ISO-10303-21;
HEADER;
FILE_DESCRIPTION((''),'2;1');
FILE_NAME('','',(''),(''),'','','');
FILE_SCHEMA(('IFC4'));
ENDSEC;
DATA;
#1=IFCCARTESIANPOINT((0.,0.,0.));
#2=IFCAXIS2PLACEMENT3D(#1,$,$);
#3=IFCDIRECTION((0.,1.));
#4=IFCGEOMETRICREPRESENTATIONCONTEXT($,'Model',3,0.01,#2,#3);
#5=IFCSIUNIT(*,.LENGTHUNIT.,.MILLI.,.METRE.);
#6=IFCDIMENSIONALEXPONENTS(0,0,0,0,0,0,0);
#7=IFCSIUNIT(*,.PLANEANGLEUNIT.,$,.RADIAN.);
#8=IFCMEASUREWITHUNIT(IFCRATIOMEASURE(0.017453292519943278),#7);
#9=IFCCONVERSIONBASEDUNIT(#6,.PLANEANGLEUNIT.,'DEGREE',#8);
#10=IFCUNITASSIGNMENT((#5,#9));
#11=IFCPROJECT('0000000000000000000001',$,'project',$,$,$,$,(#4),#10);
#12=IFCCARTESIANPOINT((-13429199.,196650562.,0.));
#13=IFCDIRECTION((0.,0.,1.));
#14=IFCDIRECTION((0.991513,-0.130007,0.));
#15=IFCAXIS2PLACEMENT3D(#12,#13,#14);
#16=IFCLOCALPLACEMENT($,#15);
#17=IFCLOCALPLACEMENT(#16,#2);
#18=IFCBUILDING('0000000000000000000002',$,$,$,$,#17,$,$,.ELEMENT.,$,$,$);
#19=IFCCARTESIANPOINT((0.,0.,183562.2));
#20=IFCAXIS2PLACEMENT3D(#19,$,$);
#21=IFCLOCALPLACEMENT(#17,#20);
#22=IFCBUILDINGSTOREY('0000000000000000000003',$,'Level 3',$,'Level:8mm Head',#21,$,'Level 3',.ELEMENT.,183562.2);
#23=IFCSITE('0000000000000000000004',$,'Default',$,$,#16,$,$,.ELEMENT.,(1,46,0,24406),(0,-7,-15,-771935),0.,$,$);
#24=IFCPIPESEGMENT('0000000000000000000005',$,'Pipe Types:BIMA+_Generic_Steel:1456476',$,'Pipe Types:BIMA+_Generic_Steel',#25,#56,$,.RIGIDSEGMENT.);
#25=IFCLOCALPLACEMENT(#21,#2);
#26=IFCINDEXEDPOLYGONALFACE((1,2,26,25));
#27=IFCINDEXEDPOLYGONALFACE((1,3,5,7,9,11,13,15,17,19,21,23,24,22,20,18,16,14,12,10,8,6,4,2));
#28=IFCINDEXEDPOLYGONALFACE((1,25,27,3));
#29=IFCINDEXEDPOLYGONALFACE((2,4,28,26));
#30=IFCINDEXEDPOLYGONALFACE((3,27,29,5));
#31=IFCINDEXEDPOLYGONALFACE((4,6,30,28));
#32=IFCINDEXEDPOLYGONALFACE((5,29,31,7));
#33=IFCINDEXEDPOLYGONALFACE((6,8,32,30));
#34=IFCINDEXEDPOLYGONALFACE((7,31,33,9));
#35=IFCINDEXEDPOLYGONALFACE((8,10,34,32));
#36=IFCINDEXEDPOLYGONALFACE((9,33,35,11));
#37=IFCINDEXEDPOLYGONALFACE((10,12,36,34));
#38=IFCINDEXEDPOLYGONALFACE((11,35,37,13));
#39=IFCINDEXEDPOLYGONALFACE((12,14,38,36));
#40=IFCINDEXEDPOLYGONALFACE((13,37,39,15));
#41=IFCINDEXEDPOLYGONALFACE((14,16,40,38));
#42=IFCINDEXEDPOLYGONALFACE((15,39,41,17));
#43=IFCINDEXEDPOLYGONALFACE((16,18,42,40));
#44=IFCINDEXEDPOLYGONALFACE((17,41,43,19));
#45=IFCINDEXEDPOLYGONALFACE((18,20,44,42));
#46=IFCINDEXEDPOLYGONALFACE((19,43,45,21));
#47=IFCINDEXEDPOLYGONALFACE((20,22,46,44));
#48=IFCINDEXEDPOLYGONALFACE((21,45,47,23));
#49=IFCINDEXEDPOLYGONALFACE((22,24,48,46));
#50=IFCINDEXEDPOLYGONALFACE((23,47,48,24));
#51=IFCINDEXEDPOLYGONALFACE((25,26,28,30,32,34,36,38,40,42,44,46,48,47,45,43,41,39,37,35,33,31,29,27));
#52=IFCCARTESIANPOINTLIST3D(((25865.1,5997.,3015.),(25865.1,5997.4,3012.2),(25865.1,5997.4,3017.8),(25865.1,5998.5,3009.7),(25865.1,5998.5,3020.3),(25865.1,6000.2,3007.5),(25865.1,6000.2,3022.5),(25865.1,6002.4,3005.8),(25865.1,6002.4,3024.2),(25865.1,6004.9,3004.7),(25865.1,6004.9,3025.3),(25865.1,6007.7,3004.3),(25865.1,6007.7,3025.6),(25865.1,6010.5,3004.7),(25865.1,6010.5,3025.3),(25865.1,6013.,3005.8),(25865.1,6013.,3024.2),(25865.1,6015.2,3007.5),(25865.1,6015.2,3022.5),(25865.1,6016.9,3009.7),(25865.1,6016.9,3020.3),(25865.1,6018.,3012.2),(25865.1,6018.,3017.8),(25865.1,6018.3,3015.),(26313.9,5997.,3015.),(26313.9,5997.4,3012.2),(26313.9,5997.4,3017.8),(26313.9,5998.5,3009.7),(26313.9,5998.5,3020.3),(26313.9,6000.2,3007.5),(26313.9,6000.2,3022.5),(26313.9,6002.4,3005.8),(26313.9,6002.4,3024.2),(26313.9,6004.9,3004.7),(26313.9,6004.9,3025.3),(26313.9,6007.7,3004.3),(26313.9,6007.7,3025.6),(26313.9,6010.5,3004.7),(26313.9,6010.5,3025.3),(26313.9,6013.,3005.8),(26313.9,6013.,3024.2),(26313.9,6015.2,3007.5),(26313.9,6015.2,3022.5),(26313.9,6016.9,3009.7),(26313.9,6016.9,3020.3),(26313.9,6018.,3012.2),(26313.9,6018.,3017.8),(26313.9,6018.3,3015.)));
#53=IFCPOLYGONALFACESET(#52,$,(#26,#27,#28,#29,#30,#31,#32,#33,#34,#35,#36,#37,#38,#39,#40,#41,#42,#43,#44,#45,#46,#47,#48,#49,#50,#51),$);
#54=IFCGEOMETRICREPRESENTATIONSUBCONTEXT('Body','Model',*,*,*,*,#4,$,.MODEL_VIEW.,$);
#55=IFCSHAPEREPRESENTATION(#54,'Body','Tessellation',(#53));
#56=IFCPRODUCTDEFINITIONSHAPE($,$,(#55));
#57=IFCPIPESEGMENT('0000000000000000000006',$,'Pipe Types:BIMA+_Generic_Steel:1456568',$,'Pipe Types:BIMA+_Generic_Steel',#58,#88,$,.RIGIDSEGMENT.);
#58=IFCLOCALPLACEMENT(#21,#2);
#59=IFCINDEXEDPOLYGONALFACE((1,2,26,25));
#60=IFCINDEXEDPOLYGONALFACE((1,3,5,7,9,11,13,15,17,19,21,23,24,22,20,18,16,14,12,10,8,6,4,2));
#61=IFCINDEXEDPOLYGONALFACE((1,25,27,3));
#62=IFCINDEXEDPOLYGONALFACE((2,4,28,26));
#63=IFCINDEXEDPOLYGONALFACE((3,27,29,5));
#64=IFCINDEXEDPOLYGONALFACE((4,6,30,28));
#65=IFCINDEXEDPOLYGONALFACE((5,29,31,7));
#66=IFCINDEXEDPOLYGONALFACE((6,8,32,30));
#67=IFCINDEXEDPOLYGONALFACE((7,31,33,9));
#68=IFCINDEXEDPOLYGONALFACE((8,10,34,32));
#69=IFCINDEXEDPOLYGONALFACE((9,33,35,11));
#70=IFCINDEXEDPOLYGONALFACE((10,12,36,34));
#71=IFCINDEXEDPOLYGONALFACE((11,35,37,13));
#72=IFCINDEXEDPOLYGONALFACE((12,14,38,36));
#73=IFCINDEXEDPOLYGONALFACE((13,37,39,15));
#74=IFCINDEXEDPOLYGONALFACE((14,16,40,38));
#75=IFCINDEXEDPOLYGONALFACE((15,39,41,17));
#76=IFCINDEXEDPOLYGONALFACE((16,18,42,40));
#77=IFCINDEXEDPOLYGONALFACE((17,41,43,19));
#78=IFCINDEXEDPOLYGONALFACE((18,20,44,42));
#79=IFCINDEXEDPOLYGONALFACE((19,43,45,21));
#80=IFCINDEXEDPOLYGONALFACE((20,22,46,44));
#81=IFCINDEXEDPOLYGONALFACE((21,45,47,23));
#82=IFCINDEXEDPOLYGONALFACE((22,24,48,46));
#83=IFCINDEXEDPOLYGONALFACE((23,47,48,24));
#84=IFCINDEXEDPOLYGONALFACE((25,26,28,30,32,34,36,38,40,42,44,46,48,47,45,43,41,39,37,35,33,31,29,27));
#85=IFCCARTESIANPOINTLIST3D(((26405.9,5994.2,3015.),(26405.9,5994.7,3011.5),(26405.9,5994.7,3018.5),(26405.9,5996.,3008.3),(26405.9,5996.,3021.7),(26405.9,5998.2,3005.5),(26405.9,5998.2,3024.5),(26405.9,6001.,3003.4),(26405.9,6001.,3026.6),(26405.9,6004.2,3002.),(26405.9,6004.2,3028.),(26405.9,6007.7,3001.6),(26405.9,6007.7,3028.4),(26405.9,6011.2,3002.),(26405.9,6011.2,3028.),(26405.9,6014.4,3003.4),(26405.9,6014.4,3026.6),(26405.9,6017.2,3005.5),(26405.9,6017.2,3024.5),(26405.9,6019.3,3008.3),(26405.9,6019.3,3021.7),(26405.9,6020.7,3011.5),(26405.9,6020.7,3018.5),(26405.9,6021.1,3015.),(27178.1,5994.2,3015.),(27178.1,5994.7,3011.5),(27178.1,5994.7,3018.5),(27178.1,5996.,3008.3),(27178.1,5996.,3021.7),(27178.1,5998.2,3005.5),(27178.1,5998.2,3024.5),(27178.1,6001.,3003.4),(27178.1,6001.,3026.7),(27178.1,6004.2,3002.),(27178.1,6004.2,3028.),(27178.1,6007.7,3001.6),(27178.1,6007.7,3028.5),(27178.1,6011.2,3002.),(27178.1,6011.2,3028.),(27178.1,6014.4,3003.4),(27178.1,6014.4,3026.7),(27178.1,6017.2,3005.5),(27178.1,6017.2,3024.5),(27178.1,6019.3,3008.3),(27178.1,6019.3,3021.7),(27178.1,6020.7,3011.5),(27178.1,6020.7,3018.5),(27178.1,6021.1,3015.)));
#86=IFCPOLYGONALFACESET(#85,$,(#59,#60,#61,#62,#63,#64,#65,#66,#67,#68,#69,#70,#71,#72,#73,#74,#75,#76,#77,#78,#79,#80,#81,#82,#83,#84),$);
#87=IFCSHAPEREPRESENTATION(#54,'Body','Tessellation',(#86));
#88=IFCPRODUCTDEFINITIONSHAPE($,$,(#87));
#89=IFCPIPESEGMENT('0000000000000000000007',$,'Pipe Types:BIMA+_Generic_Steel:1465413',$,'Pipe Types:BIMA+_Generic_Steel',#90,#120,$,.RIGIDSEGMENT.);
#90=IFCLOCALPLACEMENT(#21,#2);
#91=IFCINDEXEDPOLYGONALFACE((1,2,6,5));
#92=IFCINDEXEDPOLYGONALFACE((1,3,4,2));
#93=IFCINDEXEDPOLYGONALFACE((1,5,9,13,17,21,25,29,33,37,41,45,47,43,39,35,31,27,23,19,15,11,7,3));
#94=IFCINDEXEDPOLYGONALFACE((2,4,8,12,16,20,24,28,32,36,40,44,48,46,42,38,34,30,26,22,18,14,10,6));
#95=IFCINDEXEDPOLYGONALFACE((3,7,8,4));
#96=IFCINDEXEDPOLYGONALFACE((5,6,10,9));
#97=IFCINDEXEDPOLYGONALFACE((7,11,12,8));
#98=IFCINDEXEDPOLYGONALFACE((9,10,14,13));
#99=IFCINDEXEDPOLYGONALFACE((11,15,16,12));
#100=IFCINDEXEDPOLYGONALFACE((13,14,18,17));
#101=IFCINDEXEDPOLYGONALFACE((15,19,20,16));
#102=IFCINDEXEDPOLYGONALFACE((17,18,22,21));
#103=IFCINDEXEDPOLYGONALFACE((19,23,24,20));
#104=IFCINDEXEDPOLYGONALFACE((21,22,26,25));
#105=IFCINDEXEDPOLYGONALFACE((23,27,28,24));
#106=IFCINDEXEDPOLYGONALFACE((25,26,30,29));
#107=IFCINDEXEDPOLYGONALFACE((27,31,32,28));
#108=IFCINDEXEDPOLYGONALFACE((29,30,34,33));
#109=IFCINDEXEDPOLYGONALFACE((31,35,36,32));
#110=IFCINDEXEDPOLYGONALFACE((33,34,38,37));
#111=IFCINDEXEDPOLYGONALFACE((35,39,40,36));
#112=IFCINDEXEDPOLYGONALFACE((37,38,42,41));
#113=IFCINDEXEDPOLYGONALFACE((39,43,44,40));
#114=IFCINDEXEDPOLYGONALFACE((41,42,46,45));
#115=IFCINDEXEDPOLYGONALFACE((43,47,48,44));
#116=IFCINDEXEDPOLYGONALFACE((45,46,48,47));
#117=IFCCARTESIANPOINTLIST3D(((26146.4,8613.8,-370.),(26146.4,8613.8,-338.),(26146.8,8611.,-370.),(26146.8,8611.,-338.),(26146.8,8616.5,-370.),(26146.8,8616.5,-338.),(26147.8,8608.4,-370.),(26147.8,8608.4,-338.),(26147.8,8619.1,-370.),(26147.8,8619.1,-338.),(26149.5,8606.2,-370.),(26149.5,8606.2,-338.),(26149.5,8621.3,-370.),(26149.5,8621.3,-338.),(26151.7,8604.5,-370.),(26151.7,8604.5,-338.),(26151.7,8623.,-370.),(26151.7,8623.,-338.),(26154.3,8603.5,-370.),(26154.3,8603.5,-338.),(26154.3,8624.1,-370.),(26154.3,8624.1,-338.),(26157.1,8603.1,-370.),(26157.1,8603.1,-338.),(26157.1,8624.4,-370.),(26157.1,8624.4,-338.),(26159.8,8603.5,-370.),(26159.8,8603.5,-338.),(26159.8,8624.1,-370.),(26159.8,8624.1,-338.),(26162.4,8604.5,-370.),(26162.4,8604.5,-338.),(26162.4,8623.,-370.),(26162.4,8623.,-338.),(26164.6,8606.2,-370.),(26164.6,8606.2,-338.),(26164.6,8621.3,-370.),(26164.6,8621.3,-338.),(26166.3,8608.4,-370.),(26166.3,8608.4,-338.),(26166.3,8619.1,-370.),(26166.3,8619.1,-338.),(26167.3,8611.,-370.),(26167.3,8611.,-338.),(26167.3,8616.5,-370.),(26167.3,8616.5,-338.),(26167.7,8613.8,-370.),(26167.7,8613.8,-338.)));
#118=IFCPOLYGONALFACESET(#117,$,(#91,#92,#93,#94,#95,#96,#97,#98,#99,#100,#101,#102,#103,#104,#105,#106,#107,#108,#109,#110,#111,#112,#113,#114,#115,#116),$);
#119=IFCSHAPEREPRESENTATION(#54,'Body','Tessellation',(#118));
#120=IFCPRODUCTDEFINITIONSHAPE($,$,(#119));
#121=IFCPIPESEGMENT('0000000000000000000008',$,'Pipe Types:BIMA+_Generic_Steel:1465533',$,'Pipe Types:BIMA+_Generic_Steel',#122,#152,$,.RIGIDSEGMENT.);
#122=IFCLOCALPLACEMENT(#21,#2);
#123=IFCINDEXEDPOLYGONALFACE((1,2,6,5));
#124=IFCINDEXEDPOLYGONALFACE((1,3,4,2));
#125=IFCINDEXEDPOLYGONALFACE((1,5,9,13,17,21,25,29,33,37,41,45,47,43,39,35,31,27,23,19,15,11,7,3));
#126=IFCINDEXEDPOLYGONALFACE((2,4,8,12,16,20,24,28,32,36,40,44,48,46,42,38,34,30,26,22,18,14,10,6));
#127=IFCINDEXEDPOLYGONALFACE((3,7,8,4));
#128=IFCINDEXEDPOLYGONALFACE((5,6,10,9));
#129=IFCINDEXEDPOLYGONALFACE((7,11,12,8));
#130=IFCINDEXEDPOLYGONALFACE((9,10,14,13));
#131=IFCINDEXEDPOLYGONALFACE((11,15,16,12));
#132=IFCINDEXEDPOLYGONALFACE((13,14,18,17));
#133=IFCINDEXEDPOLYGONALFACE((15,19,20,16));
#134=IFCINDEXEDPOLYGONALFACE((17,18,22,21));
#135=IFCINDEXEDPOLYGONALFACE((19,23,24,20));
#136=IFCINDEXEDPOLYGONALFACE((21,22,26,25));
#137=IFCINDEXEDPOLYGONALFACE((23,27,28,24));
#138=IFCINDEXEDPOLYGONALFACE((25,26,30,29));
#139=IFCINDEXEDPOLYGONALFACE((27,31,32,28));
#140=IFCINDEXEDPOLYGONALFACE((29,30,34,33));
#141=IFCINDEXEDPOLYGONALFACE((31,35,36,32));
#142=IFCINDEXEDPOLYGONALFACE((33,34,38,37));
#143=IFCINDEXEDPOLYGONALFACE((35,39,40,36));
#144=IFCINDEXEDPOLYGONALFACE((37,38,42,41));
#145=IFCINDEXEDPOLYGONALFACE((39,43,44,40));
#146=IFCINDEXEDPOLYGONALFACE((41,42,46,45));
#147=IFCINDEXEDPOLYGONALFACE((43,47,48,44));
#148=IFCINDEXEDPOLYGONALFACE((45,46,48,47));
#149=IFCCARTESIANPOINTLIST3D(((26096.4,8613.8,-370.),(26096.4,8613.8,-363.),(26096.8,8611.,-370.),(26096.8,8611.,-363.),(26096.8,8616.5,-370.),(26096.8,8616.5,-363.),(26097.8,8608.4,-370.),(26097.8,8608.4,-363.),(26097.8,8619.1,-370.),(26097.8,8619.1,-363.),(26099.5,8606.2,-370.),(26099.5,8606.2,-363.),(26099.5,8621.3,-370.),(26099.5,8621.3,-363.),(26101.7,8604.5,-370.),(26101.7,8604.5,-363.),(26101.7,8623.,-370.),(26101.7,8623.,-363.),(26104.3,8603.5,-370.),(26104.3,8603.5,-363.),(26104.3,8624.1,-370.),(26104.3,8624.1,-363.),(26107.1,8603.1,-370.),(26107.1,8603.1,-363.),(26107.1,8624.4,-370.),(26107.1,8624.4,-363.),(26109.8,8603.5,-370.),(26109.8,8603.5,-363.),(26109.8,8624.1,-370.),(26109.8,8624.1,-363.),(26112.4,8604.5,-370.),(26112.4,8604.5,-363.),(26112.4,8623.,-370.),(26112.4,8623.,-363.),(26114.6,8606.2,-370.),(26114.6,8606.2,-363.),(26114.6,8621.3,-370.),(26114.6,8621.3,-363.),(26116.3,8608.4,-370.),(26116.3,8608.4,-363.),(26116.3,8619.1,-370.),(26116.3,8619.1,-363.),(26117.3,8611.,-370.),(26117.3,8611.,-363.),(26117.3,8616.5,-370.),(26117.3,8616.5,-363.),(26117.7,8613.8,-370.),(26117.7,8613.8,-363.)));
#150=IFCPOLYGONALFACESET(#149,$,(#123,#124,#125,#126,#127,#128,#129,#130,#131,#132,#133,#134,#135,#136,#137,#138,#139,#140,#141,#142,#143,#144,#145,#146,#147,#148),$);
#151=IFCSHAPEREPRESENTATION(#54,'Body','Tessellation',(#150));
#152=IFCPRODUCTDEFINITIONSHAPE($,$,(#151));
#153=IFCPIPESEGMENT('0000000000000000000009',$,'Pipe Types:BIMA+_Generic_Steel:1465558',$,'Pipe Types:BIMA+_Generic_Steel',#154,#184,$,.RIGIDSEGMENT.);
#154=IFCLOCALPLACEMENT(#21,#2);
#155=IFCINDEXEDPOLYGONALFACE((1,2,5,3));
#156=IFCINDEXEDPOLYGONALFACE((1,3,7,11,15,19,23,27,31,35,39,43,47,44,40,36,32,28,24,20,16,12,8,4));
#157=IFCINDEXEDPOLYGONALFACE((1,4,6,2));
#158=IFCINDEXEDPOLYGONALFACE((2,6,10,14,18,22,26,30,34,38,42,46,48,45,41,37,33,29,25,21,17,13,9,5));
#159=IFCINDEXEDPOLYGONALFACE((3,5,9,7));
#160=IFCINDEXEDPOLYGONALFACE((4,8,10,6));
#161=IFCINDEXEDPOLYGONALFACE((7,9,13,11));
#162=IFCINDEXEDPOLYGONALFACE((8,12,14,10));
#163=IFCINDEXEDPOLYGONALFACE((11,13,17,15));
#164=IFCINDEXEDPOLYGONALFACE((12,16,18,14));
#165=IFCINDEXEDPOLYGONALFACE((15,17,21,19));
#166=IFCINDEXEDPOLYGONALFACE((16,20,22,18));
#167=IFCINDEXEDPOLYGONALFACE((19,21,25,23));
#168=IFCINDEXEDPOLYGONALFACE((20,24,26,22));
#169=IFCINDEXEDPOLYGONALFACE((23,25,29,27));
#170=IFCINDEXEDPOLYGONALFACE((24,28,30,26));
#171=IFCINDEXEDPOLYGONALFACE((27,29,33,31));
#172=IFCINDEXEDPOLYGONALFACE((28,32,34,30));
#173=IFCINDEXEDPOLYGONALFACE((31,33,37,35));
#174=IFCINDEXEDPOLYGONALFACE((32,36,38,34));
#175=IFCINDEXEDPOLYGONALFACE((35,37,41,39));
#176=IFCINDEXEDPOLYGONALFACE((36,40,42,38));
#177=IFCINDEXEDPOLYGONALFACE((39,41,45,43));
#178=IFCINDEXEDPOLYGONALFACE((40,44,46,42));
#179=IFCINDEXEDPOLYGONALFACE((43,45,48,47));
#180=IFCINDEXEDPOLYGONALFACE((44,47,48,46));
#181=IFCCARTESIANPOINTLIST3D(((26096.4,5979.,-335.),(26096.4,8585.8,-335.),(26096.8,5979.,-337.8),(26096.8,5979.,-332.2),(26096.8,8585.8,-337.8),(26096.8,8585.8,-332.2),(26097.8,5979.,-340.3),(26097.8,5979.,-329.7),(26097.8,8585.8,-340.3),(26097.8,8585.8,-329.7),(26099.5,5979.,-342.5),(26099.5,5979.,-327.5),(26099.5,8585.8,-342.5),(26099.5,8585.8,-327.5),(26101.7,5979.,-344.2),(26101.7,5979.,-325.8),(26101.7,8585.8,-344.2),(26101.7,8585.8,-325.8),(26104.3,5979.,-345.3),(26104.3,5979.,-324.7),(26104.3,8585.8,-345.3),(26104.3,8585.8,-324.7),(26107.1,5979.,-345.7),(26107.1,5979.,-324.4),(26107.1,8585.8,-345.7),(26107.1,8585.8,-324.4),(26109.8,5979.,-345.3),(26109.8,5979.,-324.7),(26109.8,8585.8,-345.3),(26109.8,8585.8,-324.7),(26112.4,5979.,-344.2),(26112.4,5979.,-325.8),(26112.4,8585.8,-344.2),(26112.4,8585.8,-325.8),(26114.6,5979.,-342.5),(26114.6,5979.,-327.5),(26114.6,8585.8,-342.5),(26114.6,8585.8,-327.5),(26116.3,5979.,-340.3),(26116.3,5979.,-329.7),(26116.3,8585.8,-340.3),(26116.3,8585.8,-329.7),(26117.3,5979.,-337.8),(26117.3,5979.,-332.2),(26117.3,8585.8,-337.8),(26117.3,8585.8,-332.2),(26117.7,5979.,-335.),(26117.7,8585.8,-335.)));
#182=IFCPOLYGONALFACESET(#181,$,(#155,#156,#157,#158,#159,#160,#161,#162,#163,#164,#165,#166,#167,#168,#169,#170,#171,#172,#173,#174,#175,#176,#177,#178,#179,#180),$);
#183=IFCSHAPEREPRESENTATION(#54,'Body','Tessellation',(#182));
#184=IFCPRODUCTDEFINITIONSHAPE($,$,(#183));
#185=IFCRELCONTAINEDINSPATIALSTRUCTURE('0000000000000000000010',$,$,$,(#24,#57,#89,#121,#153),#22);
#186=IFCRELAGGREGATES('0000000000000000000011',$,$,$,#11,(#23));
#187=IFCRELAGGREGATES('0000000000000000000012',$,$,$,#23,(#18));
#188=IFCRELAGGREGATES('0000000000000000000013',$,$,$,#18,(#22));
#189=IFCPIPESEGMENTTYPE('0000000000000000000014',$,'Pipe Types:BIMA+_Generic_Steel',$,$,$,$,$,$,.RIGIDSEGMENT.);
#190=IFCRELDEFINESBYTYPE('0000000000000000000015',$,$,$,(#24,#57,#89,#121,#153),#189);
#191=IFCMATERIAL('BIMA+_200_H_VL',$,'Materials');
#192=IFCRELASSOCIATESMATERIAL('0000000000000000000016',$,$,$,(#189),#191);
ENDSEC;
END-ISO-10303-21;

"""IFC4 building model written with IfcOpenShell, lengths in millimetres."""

from ifc_helpers import new_model, entity, si_unit, converted_unit, direction, frame, origin, place, context, subcontext, project, spatial, arc, indexed_curve, outline, extrude, material, type_object, element, save


model = new_model("IFC4")

# Units and contexts
model_context = context("Model", 3, precision=0.01, world=origin(), true_north=direction((0.0, 1.0)))
body_context = subcontext(model_context, "Body", "Model", "MODEL_VIEW")
ifc_project = project(units=[si_unit("LENGTHUNIT", "METRE", prefix="MILLI"), converted_unit("PLANEANGLEUNIT", "DEGREE", entity("IfcRatioMeasure", 0.017453292519943278), si_unit("PLANEANGLEUNIT", "RADIAN"), dimensions=[0, 0, 0, 0, 0, 0, 0])], contexts=[model_context])

# Site, building, storey
site_placement = place(None, frame((-13429199.0, 196650562.0, 0.0), z_axis=(0.0, 0.0, 1.0), x_axis=(0.991513, -0.130007, 0.0)))
site = spatial("IfcSite", under=ifc_project, at=site_placement, Name="Default", CompositionType="ELEMENT", RefLatitude=(1, 46, 0, 24406), RefLongitude=(0, -7, -15, -771935), RefElevation=0.0)
building_placement = place(site_placement, origin())
building = spatial("IfcBuilding", under=site, at=building_placement, CompositionType="ELEMENT")
storey_placement = place(building_placement, frame((0.0, 0.0, 183562.2)))
storey = spatial("IfcBuildingStorey", under=building, at=storey_placement, Name="Level 3", ObjectType="Level:8mm Head", LongName="Level 3", CompositionType="ELEMENT", Elevation=183562.2)

# Pipe segments
ifc_material_1 = material(Name="BIMA+_200_H_VL", Category="Materials")
pipe_segment_type = type_object("IfcPipeSegmentType", Name="Pipe Types:BIMA+_Generic_Steel", PredefinedType="RIGIDSEGMENT", material=ifc_material_1)
pipe_segment_1_placement = place(storey_placement, frame((25865.1, 5995.5, 3002.8)))
element("IfcPipeSegment", 1, at=pipe_segment_1_placement, inside=storey, type_object=pipe_segment_type, Name="Pipe Types:BIMA+_Generic_Steel:1456476", ObjectType="Pipe Types:BIMA+_Generic_Steel", PredefinedType="RIGIDSEGMENT", context=body_context, shape_type="SweptSolid", body=[
    extrude(outline(indexed_curve([(10.7, 0.0), (7.5, 7.5), (0.0, 10.6), (-7.5, 7.5), (-10.6, 0.0), (-7.5, -7.5), (0.0, -10.7), (7.5, -7.5)], segments=[arc(1, 2, 3), arc(3, 4, 5), arc(5, 6, 7), arc(7, 8, 1)], self_intersect=False)), frame((0.0, 12.2, 12.2), z_axis=(1.0, 0.0, 0.0), x_axis=(0.0, 1.0, 0.0)), (0.0, 0.0, 1.0), 448.8),
])
pipe_segment_2_placement = place(storey_placement, frame((26405.9, 5992.7, 3000.0)))
element("IfcPipeSegment", 2, at=pipe_segment_2_placement, inside=storey, type_object=pipe_segment_type, Name="Pipe Types:BIMA+_Generic_Steel:1456568", ObjectType="Pipe Types:BIMA+_Generic_Steel", PredefinedType="RIGIDSEGMENT", context=body_context, shape_type="SweptSolid", body=[
    extrude(outline(indexed_curve([(13.5, 0.0), (9.5, 9.5), (0.0, 13.4), (-9.5, 9.5), (-13.5, 0.0), (-9.5, -9.5), (0.0, -13.5), (9.5, -9.5)], segments=[arc(1, 2, 3), arc(3, 4, 5), arc(5, 6, 7), arc(7, 8, 1)], self_intersect=False)), frame((0.0, 15.0, 15.0), z_axis=(1.0, 0.0, 0.000007), x_axis=(0.0, 1.0, 0.0)), (0.0, 0.0, 1.0), 772.2),
])
pipe_segment_3_placement = place(storey_placement, frame((26144.8, 8601.5, -370.0)))
element("IfcPipeSegment", 3, at=pipe_segment_3_placement, inside=storey, type_object=pipe_segment_type, Name="Pipe Types:BIMA+_Generic_Steel:1465413", ObjectType="Pipe Types:BIMA+_Generic_Steel", PredefinedType="RIGIDSEGMENT", context=body_context, shape_type="SweptSolid", body=[
    extrude(outline(indexed_curve([(10.7, 0.0), (7.5, 7.5), (0.0, 10.6), (-7.5, 7.5), (-10.7, 0.0), (-7.5, -7.5), (0.0, -10.6), (7.5, -7.5)], segments=[arc(1, 2, 3), arc(3, 4, 5), arc(5, 6, 7), arc(7, 8, 1)], self_intersect=False)), frame((12.2, 12.2, 0.0), z_axis=(0.0, 0.0, 1.0), x_axis=(-1.0, 0.0, 0.0)), (0.0, 0.0, 1.0), 32.0),
])
pipe_segment_4_placement = place(storey_placement, frame((26094.8, 8601.5, -370.0)))
element("IfcPipeSegment", 4, at=pipe_segment_4_placement, inside=storey, type_object=pipe_segment_type, Name="Pipe Types:BIMA+_Generic_Steel:1465533", ObjectType="Pipe Types:BIMA+_Generic_Steel", PredefinedType="RIGIDSEGMENT", context=body_context, shape_type="SweptSolid", body=[
    extrude(outline(indexed_curve([(10.7, 0.0), (7.5, 7.5), (0.0, 10.6), (-7.5, 7.5), (-10.7, 0.0), (-7.5, -7.5), (0.0, -10.6), (7.5, -7.5)], segments=[arc(1, 2, 3), arc(3, 4, 5), arc(5, 6, 7), arc(7, 8, 1)], self_intersect=False)), frame((12.2, 12.2, 0.0)), (0.0, 0.0, 1.0), 7.0),
])
pipe_segment_5_placement = place(storey_placement, frame((26094.8, 5979.0, -347.2)))
element("IfcPipeSegment", 5, at=pipe_segment_5_placement, inside=storey, type_object=pipe_segment_type, Name="Pipe Types:BIMA+_Generic_Steel:1465558", ObjectType="Pipe Types:BIMA+_Generic_Steel", PredefinedType="RIGIDSEGMENT", context=body_context, shape_type="SweptSolid", body=[
    extrude(outline(indexed_curve([(10.7, 0.0), (7.5, 7.5), (0.0, 10.7), (-7.5, 7.5), (-10.7, 0.0), (-7.5, -7.5), (0.0, -10.7), (7.5, -7.5)], segments=[arc(1, 2, 3), arc(3, 4, 5), arc(5, 6, 7), arc(7, 8, 1)], self_intersect=False)), frame((12.2, 0.0, 12.2), z_axis=(0.0, 1.0, 0.0), x_axis=(1.0, 0.0, 0.0)), (0.0, 0.0, 1.0), 2606.7),
])

save(model, "model.ifc")
